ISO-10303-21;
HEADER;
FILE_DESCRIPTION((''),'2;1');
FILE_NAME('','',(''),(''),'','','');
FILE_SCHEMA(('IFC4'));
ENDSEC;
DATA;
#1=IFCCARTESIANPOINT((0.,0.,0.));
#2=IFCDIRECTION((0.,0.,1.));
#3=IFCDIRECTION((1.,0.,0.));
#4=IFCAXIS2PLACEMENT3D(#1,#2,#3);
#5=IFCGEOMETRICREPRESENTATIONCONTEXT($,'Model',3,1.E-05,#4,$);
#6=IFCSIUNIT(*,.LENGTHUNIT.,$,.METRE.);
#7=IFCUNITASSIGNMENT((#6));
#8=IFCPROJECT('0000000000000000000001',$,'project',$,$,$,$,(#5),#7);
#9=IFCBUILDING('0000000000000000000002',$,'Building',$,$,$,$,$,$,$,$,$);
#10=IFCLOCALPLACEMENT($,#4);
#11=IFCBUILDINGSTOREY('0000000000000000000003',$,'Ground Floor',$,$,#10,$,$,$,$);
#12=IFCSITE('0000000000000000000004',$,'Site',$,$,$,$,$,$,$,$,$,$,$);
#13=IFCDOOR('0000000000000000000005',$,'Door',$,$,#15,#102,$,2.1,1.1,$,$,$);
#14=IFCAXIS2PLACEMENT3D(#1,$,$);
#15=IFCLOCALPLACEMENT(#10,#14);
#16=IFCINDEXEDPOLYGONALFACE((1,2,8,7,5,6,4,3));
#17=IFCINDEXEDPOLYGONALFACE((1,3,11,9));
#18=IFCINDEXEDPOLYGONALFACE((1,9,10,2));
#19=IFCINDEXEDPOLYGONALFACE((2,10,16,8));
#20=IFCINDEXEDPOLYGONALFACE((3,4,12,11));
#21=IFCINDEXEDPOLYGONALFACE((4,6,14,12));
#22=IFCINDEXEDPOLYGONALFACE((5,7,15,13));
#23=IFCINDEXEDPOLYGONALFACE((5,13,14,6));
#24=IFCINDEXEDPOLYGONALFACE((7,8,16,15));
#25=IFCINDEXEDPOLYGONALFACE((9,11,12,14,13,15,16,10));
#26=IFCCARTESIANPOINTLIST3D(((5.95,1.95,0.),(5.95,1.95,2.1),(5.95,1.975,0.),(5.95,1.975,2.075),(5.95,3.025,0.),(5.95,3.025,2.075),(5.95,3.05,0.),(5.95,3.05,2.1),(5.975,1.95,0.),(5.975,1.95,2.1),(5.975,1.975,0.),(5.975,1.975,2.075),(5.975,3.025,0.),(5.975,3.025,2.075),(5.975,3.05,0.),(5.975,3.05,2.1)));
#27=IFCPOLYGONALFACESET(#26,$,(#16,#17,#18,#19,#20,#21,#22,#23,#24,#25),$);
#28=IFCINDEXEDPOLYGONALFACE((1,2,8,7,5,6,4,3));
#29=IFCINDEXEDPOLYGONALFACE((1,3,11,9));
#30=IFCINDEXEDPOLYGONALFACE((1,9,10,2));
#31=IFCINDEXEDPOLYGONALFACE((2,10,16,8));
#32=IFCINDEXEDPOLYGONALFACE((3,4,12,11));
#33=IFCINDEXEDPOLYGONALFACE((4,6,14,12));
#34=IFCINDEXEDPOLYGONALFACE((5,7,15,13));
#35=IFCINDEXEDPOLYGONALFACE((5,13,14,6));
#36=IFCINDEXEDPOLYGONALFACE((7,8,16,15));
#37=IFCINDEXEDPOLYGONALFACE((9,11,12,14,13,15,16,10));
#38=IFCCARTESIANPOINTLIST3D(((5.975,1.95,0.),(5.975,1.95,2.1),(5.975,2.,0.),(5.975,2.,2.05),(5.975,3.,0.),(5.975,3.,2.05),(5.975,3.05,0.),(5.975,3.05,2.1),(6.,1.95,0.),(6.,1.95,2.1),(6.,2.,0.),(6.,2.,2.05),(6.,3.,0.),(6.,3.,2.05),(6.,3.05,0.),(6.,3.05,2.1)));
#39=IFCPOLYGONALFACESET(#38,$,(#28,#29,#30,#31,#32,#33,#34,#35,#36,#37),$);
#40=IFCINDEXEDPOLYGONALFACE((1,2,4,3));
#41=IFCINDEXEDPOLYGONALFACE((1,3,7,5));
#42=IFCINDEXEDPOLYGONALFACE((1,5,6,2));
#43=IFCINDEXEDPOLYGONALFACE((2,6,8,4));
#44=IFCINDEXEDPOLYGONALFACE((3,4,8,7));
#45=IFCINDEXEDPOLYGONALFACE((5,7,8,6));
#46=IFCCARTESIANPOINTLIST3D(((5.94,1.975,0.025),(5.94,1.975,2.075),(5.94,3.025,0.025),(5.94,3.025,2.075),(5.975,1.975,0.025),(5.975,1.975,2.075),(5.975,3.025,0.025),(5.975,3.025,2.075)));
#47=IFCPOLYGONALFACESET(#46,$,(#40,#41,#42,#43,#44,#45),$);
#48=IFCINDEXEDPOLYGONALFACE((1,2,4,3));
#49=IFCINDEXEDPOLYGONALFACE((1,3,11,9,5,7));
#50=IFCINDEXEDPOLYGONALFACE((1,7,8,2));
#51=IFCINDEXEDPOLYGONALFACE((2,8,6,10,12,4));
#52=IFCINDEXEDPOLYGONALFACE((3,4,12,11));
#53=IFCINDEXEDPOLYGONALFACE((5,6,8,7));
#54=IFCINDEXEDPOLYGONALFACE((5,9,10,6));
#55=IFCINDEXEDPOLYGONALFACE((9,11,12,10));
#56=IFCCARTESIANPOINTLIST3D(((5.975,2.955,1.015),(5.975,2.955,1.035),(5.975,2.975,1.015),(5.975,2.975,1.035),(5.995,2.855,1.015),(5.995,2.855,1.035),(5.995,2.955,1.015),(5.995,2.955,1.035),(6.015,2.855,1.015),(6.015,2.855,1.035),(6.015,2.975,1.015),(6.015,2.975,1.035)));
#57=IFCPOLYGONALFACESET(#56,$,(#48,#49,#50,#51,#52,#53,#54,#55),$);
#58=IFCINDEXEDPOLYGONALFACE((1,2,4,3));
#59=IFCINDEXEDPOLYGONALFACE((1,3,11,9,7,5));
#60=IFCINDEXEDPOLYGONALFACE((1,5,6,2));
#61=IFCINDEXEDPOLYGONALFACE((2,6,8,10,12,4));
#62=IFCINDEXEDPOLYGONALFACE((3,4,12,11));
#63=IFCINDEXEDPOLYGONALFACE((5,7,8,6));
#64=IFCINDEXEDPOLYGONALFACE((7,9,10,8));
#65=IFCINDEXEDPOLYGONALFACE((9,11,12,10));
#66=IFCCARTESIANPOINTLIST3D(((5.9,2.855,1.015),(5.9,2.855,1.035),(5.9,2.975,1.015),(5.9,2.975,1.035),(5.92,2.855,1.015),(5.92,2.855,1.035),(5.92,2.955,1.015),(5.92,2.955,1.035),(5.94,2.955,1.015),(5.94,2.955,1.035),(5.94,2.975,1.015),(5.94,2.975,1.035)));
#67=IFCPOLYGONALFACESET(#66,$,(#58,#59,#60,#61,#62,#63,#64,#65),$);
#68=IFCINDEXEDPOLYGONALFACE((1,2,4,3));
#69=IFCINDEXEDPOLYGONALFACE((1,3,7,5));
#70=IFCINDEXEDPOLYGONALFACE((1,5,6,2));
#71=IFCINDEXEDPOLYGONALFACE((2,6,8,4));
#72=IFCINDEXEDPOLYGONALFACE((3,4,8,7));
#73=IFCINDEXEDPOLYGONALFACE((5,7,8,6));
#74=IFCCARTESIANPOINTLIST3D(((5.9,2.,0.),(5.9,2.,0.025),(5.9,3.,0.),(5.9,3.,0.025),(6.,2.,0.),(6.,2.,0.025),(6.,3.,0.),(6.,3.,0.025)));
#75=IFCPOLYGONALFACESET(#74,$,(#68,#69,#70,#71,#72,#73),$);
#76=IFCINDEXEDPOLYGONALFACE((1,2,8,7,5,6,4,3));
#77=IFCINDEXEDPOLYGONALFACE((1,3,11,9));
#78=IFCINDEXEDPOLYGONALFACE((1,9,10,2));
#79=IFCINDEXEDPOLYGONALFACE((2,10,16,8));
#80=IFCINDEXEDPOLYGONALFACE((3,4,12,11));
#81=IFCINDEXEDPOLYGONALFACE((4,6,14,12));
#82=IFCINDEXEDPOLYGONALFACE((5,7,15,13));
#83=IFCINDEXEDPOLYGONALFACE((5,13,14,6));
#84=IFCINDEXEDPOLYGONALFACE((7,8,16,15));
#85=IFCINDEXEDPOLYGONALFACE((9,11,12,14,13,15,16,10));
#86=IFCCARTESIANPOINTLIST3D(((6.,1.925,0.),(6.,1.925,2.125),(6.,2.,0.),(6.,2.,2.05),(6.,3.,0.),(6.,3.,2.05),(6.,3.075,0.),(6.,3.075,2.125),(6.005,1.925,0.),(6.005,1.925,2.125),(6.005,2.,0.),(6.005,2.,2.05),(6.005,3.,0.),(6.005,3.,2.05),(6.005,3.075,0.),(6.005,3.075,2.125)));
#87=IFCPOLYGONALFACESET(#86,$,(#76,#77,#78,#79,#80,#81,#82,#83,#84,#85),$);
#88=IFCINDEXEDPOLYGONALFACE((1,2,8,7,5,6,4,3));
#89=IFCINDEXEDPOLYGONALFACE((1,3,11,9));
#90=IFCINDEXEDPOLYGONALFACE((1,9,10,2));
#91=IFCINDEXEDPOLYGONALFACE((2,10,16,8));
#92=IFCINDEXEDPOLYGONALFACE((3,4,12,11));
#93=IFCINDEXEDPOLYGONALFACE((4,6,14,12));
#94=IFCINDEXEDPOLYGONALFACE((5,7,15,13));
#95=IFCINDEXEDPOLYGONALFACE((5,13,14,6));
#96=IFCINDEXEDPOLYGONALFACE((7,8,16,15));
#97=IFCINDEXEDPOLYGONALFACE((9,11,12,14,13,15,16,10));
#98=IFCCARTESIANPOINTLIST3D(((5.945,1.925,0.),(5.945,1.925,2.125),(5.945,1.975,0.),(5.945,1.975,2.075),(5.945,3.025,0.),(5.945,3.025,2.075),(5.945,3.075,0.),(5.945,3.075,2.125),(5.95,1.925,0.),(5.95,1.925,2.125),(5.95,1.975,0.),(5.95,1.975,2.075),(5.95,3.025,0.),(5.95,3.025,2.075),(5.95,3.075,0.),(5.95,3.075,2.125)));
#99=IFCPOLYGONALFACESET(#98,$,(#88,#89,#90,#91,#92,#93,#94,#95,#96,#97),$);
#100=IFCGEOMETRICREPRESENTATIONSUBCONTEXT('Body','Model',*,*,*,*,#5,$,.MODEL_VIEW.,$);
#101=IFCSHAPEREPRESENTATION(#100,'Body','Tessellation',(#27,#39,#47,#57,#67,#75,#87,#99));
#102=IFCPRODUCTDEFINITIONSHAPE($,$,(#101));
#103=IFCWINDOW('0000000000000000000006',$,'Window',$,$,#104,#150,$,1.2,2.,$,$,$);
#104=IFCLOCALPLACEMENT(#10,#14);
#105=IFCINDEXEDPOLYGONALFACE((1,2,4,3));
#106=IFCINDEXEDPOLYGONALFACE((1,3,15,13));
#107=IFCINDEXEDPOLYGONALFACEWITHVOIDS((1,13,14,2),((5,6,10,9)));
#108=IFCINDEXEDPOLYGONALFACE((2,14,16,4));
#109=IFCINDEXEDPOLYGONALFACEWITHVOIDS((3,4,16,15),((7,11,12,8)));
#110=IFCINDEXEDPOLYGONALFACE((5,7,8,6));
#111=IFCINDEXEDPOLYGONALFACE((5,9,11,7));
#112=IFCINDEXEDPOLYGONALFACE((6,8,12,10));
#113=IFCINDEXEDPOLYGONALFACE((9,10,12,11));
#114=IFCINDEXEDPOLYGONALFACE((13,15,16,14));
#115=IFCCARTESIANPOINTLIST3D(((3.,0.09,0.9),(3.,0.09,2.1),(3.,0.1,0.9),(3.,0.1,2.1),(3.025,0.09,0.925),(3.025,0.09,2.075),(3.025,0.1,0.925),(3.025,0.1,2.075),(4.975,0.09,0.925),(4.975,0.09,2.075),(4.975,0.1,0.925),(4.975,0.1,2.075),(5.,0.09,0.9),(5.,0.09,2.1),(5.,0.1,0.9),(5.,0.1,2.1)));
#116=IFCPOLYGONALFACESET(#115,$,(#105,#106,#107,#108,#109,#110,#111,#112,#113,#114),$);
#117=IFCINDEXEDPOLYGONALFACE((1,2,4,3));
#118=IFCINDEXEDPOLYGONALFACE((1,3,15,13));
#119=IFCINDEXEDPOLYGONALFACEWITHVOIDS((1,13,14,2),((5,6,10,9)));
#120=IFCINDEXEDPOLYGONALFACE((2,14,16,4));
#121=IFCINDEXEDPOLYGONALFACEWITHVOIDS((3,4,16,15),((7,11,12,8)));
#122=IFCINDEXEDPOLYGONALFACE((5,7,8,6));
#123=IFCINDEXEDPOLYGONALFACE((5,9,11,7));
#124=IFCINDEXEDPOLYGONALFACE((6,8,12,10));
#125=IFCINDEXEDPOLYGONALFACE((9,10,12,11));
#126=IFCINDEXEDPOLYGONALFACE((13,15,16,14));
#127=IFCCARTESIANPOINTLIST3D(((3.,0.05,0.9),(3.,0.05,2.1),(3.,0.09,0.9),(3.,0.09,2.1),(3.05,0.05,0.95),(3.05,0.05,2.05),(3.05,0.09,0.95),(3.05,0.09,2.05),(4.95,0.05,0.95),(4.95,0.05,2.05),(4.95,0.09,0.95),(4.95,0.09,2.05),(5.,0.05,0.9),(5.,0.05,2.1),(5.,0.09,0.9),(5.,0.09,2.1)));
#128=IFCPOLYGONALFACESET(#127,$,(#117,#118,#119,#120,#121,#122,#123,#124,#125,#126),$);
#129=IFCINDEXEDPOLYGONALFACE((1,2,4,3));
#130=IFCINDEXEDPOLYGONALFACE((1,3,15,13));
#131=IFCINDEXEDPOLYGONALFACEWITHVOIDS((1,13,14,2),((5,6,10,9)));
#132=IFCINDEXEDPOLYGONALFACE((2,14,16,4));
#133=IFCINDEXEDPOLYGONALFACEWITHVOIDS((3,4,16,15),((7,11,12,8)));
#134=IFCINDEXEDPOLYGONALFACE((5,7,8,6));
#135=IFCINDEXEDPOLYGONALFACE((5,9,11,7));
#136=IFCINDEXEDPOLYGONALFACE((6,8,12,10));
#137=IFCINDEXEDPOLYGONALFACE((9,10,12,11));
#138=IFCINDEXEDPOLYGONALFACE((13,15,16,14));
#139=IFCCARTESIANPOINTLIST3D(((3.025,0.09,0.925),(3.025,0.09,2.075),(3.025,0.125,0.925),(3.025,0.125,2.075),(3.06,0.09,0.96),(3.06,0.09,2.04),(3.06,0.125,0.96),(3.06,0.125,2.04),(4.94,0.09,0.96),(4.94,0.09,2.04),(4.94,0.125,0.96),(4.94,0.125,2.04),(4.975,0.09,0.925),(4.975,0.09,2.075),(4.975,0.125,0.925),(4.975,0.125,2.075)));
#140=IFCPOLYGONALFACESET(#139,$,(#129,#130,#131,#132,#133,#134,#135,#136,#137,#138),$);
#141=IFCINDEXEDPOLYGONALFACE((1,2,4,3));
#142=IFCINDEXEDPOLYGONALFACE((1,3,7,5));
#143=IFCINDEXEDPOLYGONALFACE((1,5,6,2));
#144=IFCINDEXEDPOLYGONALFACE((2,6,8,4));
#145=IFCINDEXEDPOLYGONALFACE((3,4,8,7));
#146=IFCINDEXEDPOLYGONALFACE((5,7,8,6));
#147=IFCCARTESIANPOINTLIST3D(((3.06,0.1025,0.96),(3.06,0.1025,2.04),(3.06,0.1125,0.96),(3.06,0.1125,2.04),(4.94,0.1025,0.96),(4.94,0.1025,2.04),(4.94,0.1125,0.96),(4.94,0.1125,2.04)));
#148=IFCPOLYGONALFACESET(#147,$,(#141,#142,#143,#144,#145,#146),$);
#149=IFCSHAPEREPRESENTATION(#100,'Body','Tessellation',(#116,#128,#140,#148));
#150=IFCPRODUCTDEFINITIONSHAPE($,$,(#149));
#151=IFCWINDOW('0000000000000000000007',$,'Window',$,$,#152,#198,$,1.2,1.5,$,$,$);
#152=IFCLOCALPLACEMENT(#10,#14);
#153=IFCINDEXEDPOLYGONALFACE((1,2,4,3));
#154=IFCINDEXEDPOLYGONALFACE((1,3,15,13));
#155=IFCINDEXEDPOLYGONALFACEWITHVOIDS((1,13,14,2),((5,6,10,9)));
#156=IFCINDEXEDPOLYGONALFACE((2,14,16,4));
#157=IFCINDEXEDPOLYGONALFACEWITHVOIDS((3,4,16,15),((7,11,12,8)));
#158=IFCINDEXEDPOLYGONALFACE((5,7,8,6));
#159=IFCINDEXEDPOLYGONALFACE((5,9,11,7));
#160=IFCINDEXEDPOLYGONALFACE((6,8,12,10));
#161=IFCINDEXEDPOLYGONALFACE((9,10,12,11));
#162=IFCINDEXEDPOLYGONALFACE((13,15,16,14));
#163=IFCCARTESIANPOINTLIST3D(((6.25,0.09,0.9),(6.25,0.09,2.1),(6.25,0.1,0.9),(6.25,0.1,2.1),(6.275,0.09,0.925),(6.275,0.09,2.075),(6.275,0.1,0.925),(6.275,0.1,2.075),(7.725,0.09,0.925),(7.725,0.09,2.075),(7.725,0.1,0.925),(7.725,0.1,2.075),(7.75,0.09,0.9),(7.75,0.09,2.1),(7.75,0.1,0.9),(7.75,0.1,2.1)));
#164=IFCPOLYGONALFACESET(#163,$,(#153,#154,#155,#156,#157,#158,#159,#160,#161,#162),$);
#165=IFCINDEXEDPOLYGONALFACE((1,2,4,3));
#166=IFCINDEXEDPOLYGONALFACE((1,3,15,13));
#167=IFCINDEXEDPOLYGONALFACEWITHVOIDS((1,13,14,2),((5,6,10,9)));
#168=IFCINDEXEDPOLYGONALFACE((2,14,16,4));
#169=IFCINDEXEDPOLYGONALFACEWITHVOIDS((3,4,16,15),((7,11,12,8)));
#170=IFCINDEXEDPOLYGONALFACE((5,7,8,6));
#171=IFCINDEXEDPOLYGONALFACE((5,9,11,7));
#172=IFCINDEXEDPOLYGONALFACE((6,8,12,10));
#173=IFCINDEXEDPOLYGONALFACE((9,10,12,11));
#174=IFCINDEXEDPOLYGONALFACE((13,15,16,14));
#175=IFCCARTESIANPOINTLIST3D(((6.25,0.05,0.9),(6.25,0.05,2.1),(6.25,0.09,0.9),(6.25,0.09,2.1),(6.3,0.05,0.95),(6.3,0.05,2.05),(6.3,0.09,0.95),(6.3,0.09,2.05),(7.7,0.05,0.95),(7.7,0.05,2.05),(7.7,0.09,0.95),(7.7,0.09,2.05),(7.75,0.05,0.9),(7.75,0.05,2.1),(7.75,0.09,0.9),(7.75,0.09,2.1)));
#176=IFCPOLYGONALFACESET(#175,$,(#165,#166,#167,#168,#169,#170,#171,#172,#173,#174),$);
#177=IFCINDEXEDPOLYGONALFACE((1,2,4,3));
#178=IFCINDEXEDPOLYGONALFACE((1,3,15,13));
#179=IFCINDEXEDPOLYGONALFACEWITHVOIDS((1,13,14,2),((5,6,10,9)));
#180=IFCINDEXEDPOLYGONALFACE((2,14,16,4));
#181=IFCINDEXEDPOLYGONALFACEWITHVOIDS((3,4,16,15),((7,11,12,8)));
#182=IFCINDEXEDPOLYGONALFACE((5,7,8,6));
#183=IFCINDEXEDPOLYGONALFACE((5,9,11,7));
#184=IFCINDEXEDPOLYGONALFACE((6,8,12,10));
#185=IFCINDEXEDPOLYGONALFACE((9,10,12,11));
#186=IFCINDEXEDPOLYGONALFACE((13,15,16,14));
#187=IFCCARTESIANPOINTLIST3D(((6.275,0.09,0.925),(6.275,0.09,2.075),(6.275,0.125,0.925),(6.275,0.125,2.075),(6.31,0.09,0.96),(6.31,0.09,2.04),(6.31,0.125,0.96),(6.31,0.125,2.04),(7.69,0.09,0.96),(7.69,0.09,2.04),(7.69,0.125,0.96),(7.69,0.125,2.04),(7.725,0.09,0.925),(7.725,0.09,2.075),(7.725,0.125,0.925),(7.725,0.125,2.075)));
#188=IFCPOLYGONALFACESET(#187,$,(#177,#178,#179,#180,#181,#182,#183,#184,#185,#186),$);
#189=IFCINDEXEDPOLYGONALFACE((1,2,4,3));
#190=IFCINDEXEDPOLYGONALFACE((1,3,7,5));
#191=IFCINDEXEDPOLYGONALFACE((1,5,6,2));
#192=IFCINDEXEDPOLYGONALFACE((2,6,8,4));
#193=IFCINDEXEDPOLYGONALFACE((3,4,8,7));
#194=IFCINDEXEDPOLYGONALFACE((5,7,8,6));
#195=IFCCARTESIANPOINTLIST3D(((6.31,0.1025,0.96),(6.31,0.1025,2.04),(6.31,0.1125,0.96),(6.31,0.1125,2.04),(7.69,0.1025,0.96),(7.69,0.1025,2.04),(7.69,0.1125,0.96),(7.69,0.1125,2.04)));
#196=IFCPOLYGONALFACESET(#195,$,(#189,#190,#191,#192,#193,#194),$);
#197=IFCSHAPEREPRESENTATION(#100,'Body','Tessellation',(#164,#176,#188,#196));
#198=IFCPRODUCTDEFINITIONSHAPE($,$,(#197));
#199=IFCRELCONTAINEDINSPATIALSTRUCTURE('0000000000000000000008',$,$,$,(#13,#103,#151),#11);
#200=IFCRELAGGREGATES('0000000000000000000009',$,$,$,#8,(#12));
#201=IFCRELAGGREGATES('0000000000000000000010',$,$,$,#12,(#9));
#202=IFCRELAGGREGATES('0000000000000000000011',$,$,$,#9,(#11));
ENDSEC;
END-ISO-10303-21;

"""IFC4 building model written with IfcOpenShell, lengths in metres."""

from ifc_helpers import new_model, si_unit, frame, origin_with_axes, place, context, subcontext, project, spatial, line, indexed_curve, outline, extrude, element, save


model = new_model("IFC4")

# Units and contexts
model_context = context("Model", 3, precision=1e-05, world=origin_with_axes())
body_context = subcontext(model_context, "Body", "Model", "MODEL_VIEW")
ifc_project = project(units=[si_unit("LENGTHUNIT", "METRE")], contexts=[model_context])

# Site, building, storey
site = spatial("IfcSite", under=ifc_project, Name="Site")
building = spatial("IfcBuilding", under=site, Name="Building")
storey_placement = place(None, origin_with_axes())
storey = spatial("IfcBuildingStorey", under=building, at=storey_placement, Name="Ground Floor")

# Door
door_1_placement = place(storey_placement, frame((6.0, 1.95, 0.0), z_axis=(0.0, 0.0, 1.0), x_axis=(0.0, 1.0, 0.0)))
element("IfcDoor", 1, at=door_1_placement, inside=storey, Name="Door", OverallHeight=2.1, OverallWidth=1.1, context=body_context, shape_type="SweptSolid", body=[
    extrude(outline(indexed_curve([(0.0, 0.0), (0.0, 2.1), (1.1, 2.1), (1.1, 0.0), (1.075, 0.0), (1.075, 2.075), (0.025, 2.075), (0.025, 0.0)], segments=[line(1, 2, 3, 4, 5, 6, 7, 8, 1)])), frame((0.0, 0.025, 0.0), z_axis=(0.0, -1.0, 0.0), x_axis=(1.0, 0.0, 0.0)), (0.0, 0.0, -1.0), 0.025),
    extrude(outline(indexed_curve([(0.0, 0.0), (0.0, 2.1), (1.1, 2.1), (1.1, 0.0), (1.05, 0.0), (1.05, 2.05), (0.05, 2.05), (0.05, 0.0)], segments=[line(1, 2, 3, 4, 5, 6, 7, 8, 1)])), frame((0.0, 0.0, 0.0), z_axis=(0.0, -1.0, 0.0), x_axis=(1.0, 0.0, 0.0)), (0.0, 0.0, -1.0), 0.025),
    extrude(outline(indexed_curve([(0.0, 0.0), (1.05, 0.0), (1.05, 0.035), (0.0, 0.035)], segments=[line(1, 2, 3, 4, 1)])), frame((0.025, 0.025, 0.025), z_axis=(0.0, 0.0, 1.0), x_axis=(1.0, 0.0, 0.0)), (0.0, 0.0, 1.0), 2.05),
    extrude(outline(indexed_curve([(0.0, 0.0), (0.0, -0.04), (-0.12, -0.04), (-0.12, -0.02), (-0.02, -0.02), (-0.02, 0.0)], segments=[line(1, 2, 3, 4, 5, 6, 1)])), frame((1.025, 0.025, 1.015), z_axis=(0.0, 0.0, 1.0), x_axis=(1.0, 0.0, 0.0)), (0.0, 0.0, 1.0), 0.02),
    extrude(outline(indexed_curve([(0.0, 0.0), (0.0, 0.04), (-0.12, 0.04), (-0.12, 0.02), (-0.02, 0.02), (-0.02, 0.0)], segments=[line(1, 2, 3, 4, 5, 6, 1)])), frame((1.025, 0.06, 1.015), z_axis=(0.0, 0.0, 1.0), x_axis=(1.0, 0.0, 0.0)), (0.0, 0.0, 1.0), 0.02),
    extrude(outline(indexed_curve([(0.0, 0.0), (1.0, 0.0), (1.0, 0.1), (0.0, 0.1)], segments=[line(1, 2, 3, 4, 1)])), frame((0.05, 0.0, 0.0), z_axis=(0.0, 0.0, 1.0), x_axis=(1.0, 0.0, 0.0)), (0.0, 0.0, 1.0), 0.025),
    extrude(outline(indexed_curve([(0.0, 0.0), (0.0, 2.125), (1.15, 2.125), (1.15, 0.0), (1.075, 0.0), (1.075, 2.05), (0.075, 2.05), (0.075, 0.0)], segments=[line(1, 2, 3, 4, 5, 6, 7, 8, 1)])), frame((-0.025, -0.005, 0.0), z_axis=(0.0, -1.0, 0.0), x_axis=(1.0, 0.0, 0.0)), (0.0, 0.0, -1.0), 0.005),
    extrude(outline(indexed_curve([(0.0, 0.0), (0.0, 2.125), (1.15, 2.125), (1.15, 0.0), (1.1, 0.0), (1.1, 2.075), (0.05, 2.075), (0.05, 0.0)], segments=[line(1, 2, 3, 4, 5, 6, 7, 8, 1)])), frame((-0.025, 0.05, 0.0), z_axis=(0.0, -1.0, 0.0), x_axis=(1.0, 0.0, 0.0)), (0.0, 0.0, -1.0), 0.005),
])

# Windows
window_1_placement = place(storey_placement, frame((3.0, 0.0, 0.9), z_axis=(0.0, 0.0, 1.0), x_axis=(1.0, 0.0, 0.0)))
element("IfcWindow", 2, at=window_1_placement, inside=storey, Name="Window", OverallHeight=1.2, OverallWidth=2.0, context=body_context, shape_type="SweptSolid", body=[
    extrude(outline(indexed_curve([(0.0, 0.0), (2.0, 0.0), (2.0, 1.2), (0.0, 1.2)], segments=[line(1, 2, 3, 4, 1)]), holes=[indexed_curve([(0.025, 0.025), (1.975, 0.025), (1.975, 1.175), (0.025, 1.175)], segments=[line(1, 2, 3, 4, 1)])]), frame((0.0, 0.09, 0.0), z_axis=(0.0, -1.0, 0.0), x_axis=(1.0, 0.0, 0.0)), (0.0, 0.0, -1.0), 0.01),
    extrude(outline(indexed_curve([(0.0, 0.0), (2.0, 0.0), (2.0, 1.2), (0.0, 1.2)], segments=[line(1, 2, 3, 4, 1)]), holes=[indexed_curve([(0.05, 0.05), (1.95, 0.05), (1.95, 1.15), (0.05, 1.15)], segments=[line(1, 2, 3, 4, 1)])]), frame((0.0, 0.05, 0.0), z_axis=(0.0, -1.0, 0.0), x_axis=(1.0, 0.0, 0.0)), (0.0, 0.0, -1.0), 0.04),
    extrude(outline(indexed_curve([(0.0, 0.0), (1.95, 0.0), (1.95, 1.15), (0.0, 1.15)], segments=[line(1, 2, 3, 4, 1)]), holes=[indexed_curve([(0.035, 0.035), (1.915, 0.035), (1.915, 1.115), (0.035, 1.115)], segments=[line(1, 2, 3, 4, 1)])]), frame((0.025, 0.09, 0.025), z_axis=(0.0, -1.0, 0.0), x_axis=(1.0, 0.0, 0.0)), (0.0, 0.0, -1.0), 0.035),
    extrude(outline(indexed_curve([(0.035, 0.035), (1.915, 0.035), (1.915, 1.115), (0.035, 1.115)], segments=[line(1, 2, 3, 4, 1)])), frame((0.025, 0.1025, 0.025), z_axis=(0.0, -1.0, 0.0), x_axis=(1.0, 0.0, 0.0)), (0.0, 0.0, -1.0), 0.01),
])
window_2_placement = place(storey_placement, frame((6.25, 0.0, 0.9), z_axis=(0.0, 0.0, 1.0), x_axis=(1.0, 0.0, 0.0)))
element("IfcWindow", 3, at=window_2_placement, inside=storey, Name="Window", OverallHeight=1.2, OverallWidth=1.5, context=body_context, shape_type="SweptSolid", body=[
    extrude(outline(indexed_curve([(0.0, 0.0), (1.5, 0.0), (1.5, 1.2), (0.0, 1.2)], segments=[line(1, 2, 3, 4, 1)]), holes=[indexed_curve([(0.025, 0.025), (1.475, 0.025), (1.475, 1.175), (0.025, 1.175)], segments=[line(1, 2, 3, 4, 1)])]), frame((0.0, 0.09, 0.0), z_axis=(0.0, -1.0, 0.0), x_axis=(1.0, 0.0, 0.0)), (0.0, 0.0, -1.0), 0.01),
    extrude(outline(indexed_curve([(0.0, 0.0), (1.5, 0.0), (1.5, 1.2), (0.0, 1.2)], segments=[line(1, 2, 3, 4, 1)]), holes=[indexed_curve([(0.05, 0.05), (1.45, 0.05), (1.45, 1.15), (0.05, 1.15)], segments=[line(1, 2, 3, 4, 1)])]), frame((0.0, 0.05, 0.0), z_axis=(0.0, -1.0, 0.0), x_axis=(1.0, 0.0, 0.0)), (0.0, 0.0, -1.0), 0.04),
    extrude(outline(indexed_curve([(0.0, 0.0), (1.45, 0.0), (1.45, 1.15), (0.0, 1.15)], segments=[line(1, 2, 3, 4, 1)]), holes=[indexed_curve([(0.035, 0.035), (1.415, 0.035), (1.415, 1.115), (0.035, 1.115)], segments=[line(1, 2, 3, 4, 1)])]), frame((0.025, 0.09, 0.025), z_axis=(0.0, -1.0, 0.0), x_axis=(1.0, 0.0, 0.0)), (0.0, 0.0, -1.0), 0.035),
    extrude(outline(indexed_curve([(0.035, 0.035), (1.415, 0.035), (1.415, 1.115), (0.035, 1.115)], segments=[line(1, 2, 3, 4, 1)])), frame((0.025, 0.1025, 0.025), z_axis=(0.0, -1.0, 0.0), x_axis=(1.0, 0.0, 0.0)), (0.0, 0.0, -1.0), 0.01),
])

save(model, "model.ifc")
